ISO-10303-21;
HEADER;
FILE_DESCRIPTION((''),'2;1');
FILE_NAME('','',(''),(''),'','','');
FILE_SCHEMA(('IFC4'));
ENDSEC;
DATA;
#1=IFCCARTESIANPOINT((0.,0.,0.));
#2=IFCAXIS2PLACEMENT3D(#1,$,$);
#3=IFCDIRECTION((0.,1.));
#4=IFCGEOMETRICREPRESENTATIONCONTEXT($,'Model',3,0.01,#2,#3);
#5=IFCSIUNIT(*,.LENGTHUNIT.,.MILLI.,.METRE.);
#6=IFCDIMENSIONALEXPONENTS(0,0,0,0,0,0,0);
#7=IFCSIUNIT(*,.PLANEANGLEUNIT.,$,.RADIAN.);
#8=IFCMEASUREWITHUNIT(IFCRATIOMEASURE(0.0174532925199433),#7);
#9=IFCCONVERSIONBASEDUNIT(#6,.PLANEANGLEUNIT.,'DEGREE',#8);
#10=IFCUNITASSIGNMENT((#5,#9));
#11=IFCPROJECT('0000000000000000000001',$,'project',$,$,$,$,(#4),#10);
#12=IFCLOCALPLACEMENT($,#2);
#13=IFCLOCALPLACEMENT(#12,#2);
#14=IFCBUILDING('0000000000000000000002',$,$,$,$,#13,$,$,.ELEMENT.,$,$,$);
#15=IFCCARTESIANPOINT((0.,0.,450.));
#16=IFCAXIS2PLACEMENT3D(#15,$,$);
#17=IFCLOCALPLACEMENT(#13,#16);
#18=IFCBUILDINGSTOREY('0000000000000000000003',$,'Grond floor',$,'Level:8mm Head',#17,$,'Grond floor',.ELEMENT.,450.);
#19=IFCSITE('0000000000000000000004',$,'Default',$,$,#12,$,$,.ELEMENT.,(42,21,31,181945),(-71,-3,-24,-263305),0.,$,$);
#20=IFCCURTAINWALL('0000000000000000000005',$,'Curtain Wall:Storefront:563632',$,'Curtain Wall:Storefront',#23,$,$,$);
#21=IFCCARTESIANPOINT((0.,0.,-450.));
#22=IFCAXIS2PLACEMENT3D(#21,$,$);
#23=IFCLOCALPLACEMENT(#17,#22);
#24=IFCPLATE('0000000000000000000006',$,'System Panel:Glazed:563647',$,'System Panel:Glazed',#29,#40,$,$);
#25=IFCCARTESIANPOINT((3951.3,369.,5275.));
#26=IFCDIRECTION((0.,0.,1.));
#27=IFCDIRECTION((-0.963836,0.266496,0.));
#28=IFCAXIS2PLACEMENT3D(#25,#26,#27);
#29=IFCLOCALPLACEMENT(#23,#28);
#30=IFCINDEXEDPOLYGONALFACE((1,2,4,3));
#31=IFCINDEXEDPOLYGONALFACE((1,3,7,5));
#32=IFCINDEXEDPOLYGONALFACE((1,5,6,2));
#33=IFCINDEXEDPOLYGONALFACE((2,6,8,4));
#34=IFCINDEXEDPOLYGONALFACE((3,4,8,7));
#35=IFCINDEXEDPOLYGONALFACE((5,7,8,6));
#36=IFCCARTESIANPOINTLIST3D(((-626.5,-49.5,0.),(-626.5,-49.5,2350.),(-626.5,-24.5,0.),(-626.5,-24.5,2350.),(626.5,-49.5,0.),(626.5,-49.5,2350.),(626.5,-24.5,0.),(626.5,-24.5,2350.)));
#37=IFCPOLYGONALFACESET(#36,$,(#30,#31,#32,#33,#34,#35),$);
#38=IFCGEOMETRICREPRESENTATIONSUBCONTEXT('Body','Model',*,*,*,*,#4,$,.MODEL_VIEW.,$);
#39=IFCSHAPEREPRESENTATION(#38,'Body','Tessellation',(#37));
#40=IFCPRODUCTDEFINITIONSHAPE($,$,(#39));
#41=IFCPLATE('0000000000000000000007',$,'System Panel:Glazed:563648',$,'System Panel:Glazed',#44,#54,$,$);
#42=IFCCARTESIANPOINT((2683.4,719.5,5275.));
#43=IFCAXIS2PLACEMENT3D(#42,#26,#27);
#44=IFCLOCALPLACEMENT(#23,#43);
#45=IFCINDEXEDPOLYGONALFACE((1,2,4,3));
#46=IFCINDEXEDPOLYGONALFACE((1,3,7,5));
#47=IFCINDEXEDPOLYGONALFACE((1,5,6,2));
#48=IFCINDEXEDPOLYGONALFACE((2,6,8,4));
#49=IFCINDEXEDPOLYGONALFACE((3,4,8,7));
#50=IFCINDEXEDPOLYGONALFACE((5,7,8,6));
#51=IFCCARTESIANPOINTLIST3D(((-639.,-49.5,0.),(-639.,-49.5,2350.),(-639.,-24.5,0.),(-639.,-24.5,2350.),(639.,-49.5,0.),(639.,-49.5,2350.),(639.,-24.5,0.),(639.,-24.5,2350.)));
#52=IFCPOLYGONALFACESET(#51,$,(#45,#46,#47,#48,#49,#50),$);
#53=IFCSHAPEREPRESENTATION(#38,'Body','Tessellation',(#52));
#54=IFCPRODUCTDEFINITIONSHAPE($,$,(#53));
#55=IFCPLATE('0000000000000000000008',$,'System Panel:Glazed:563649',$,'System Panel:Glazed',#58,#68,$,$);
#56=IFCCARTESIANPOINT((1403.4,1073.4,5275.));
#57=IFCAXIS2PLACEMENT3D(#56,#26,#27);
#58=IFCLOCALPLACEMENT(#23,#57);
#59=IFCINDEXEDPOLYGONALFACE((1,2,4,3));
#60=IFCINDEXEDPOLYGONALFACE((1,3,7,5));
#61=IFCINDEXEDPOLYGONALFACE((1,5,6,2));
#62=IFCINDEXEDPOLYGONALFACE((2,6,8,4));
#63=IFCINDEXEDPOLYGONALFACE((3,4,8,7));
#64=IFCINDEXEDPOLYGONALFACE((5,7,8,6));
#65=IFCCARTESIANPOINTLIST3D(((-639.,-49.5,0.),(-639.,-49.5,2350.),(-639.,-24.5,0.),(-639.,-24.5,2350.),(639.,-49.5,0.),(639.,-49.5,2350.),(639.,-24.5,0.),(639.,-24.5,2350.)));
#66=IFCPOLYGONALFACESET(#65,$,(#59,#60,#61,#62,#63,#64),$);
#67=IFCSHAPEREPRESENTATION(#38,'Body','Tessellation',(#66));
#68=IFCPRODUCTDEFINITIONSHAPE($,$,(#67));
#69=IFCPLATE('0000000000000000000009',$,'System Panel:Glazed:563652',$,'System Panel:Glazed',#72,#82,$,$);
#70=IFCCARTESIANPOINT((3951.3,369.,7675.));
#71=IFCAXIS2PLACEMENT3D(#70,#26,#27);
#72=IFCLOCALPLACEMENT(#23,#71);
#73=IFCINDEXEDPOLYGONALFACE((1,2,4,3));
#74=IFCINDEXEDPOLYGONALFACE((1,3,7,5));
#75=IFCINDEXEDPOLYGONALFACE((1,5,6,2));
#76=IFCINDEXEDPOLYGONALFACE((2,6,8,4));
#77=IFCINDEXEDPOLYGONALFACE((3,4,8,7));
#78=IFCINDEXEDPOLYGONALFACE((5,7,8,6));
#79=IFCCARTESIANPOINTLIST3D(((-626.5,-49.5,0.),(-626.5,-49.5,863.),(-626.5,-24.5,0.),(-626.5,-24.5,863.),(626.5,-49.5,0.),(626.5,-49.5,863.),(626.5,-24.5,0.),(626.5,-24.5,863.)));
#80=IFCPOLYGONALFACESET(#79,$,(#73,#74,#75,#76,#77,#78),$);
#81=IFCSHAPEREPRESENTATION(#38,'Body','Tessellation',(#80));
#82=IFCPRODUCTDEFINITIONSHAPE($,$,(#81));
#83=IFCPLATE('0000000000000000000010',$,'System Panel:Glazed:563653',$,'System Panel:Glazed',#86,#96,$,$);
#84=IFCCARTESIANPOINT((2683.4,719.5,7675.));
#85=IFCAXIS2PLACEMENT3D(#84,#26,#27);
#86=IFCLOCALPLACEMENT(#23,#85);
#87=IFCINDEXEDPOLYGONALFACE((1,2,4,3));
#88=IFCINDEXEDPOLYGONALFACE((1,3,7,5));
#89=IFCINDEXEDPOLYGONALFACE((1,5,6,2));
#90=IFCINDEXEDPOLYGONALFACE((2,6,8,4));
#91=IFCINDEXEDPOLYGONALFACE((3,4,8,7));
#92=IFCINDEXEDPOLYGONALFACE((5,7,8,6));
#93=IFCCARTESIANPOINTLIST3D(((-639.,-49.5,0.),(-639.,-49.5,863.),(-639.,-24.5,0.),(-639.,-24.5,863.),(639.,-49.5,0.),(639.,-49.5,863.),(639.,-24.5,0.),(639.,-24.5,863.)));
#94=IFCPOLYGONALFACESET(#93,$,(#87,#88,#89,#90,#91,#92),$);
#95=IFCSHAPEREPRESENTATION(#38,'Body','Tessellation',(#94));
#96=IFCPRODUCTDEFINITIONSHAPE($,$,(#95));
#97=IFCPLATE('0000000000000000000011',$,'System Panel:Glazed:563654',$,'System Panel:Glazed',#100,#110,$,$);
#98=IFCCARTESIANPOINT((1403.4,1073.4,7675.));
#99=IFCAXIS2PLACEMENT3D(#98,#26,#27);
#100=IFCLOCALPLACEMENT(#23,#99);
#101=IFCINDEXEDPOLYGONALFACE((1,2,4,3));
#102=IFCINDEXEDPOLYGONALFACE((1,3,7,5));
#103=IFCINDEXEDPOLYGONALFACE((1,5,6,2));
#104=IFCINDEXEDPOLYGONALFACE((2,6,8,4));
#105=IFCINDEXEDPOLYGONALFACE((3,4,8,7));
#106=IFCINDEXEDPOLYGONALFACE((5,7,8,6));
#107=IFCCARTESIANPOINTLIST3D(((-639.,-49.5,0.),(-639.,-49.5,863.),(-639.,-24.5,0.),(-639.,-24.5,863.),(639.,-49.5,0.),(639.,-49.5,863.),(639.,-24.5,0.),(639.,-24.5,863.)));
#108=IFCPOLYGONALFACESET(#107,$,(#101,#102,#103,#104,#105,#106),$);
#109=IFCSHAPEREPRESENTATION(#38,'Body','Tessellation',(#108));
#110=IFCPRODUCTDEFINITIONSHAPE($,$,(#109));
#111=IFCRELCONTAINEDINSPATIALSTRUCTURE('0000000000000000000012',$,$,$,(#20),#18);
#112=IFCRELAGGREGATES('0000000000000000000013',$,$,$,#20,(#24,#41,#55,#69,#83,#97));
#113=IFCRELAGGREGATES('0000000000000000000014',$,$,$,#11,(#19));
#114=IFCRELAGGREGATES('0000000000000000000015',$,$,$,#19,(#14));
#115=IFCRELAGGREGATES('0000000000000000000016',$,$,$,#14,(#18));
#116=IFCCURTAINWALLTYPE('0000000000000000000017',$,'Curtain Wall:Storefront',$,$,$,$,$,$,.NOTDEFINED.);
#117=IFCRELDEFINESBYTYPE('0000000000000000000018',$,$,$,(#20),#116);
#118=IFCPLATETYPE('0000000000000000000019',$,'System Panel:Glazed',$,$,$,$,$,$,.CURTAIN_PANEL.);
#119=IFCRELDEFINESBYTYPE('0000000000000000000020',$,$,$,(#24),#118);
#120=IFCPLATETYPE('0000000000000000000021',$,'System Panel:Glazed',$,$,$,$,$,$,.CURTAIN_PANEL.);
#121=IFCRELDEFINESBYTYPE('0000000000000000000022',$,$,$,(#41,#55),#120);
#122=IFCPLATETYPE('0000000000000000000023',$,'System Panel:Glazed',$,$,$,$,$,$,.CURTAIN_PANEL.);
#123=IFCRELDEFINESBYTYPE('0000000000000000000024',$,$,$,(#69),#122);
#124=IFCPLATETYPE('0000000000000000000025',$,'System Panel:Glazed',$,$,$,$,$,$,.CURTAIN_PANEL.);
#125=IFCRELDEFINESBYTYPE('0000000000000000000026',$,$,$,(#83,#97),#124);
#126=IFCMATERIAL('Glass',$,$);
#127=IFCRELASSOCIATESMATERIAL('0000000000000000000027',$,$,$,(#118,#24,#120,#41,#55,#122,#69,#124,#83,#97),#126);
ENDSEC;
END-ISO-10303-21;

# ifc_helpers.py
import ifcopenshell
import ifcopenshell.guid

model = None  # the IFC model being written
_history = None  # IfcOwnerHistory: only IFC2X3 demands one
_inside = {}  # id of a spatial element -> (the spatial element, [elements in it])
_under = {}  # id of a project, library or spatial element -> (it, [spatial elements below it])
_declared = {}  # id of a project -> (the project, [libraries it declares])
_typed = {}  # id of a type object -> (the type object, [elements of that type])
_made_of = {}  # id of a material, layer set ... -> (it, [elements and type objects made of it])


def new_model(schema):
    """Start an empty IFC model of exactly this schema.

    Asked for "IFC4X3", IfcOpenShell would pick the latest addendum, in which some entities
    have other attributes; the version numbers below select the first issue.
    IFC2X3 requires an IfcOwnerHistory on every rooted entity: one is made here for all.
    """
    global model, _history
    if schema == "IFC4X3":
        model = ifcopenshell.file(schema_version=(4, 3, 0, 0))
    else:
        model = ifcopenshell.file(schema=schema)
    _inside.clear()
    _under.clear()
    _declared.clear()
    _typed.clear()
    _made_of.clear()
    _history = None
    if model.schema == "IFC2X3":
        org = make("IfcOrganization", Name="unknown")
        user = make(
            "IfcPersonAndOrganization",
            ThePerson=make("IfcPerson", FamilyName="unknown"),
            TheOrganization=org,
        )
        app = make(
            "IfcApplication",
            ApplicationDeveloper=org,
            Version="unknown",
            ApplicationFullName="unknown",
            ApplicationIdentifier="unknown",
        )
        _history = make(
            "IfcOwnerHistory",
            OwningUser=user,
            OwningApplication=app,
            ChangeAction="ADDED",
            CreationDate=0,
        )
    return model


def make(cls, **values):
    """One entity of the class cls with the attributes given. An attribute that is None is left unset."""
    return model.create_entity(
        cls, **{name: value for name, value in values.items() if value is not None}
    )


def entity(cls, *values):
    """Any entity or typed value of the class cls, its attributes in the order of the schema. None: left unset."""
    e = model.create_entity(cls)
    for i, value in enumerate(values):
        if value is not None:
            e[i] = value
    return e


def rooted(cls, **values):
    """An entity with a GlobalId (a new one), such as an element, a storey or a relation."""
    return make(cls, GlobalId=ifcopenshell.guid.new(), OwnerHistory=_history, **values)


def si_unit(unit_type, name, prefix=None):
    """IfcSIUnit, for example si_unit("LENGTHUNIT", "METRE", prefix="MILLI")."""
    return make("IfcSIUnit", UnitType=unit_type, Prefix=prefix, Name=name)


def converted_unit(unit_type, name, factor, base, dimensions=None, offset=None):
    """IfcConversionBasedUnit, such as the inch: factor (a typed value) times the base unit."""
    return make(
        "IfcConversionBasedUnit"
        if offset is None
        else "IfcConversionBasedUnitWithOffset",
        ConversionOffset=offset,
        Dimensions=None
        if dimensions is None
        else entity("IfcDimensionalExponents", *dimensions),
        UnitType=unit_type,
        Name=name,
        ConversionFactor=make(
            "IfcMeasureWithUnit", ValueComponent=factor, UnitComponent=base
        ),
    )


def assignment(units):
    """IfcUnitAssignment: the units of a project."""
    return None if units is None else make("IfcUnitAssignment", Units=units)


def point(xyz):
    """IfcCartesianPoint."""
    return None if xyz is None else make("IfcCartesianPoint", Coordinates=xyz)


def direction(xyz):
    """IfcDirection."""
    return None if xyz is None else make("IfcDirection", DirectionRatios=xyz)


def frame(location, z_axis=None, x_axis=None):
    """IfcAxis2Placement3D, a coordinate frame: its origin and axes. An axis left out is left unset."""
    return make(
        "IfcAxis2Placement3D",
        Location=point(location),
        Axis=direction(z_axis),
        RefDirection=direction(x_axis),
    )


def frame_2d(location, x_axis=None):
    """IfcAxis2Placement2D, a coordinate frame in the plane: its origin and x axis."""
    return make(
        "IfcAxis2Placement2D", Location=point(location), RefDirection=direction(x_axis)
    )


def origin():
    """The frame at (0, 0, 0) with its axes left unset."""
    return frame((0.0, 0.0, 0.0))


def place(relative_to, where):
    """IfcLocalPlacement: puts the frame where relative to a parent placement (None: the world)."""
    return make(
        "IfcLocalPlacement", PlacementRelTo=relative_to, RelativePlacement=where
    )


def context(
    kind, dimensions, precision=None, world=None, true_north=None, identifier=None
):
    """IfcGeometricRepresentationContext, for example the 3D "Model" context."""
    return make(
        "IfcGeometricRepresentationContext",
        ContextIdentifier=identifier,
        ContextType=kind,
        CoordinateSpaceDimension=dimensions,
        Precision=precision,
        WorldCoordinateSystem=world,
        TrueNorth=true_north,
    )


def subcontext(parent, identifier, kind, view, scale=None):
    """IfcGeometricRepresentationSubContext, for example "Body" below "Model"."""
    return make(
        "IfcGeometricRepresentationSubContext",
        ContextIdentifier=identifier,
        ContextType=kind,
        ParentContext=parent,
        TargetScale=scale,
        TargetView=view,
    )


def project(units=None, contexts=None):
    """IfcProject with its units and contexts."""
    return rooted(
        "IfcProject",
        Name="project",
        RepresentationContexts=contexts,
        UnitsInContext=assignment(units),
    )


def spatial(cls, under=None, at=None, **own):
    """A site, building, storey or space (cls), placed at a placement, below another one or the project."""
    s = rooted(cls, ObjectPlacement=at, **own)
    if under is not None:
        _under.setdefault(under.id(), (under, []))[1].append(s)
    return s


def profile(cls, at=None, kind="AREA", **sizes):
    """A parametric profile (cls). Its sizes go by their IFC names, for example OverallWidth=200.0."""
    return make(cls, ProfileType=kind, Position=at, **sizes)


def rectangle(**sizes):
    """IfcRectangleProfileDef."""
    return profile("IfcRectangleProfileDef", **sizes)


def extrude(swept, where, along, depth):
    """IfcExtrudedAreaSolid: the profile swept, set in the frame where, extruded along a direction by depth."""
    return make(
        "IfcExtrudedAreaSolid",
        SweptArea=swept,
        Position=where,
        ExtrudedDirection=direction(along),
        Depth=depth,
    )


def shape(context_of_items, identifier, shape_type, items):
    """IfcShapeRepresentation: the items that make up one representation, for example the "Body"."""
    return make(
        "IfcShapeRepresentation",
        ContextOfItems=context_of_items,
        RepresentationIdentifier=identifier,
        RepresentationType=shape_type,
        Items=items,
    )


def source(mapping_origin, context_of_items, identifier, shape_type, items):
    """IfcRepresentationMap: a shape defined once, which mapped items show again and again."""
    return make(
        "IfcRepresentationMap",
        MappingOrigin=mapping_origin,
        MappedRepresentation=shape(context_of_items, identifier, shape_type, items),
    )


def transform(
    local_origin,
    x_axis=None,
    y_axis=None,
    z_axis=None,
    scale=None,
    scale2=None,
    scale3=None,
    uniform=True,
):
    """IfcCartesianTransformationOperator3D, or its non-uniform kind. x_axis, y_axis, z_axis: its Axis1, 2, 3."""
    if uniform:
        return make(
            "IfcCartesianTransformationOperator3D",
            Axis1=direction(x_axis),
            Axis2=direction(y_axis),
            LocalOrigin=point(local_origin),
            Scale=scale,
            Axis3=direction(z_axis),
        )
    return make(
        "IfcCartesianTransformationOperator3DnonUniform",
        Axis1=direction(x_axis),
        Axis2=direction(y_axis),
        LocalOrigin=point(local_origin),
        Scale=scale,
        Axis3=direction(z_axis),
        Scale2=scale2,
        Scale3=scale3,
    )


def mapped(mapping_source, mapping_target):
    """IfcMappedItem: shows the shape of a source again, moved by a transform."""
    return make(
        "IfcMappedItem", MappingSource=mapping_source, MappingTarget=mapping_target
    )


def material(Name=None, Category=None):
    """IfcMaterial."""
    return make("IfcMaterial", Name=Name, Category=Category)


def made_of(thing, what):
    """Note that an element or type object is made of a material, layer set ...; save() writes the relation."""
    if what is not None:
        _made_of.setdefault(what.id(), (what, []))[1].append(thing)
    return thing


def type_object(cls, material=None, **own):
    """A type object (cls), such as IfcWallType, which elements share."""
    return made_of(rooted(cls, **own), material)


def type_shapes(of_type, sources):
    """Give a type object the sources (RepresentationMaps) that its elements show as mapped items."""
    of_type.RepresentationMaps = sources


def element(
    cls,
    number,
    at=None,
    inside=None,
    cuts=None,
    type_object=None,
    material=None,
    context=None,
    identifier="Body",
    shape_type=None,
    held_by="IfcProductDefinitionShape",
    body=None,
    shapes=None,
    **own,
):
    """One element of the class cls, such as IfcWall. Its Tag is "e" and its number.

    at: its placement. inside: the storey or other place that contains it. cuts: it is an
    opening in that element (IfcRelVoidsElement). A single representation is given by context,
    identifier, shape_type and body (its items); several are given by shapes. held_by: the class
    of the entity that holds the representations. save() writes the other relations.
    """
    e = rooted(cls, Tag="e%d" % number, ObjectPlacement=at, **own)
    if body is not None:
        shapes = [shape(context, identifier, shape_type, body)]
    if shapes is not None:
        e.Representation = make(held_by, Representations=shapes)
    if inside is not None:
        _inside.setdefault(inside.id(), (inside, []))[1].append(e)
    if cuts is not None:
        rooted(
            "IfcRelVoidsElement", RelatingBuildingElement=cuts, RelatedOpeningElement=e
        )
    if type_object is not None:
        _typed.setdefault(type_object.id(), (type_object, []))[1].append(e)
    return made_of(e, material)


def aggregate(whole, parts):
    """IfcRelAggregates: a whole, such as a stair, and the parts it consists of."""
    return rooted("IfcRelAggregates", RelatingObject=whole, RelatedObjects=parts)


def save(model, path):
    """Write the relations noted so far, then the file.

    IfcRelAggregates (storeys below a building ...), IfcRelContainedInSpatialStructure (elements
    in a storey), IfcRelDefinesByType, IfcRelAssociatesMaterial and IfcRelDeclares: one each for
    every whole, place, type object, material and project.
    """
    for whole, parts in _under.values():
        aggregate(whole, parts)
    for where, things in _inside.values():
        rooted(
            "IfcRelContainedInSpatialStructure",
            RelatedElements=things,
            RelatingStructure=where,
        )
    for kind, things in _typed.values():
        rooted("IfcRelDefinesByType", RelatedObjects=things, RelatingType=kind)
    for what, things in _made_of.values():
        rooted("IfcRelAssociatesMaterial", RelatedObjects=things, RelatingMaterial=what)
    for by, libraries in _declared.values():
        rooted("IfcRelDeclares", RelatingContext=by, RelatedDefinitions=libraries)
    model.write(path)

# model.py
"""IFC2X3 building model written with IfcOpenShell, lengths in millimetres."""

from ifc_helpers import new_model, entity, si_unit, converted_unit, direction, frame, frame_2d, origin, place, context, subcontext, project, spatial, rectangle, extrude, source, transform, mapped, material, type_object, type_shapes, element, aggregate, save


model = new_model("IFC2X3")

# Units and contexts
model_context = context("Model", 3, precision=0.01, world=origin(), true_north=direction((0.0, 1.0)))
body_context = subcontext(model_context, "Body", "Model", "MODEL_VIEW")
ifc_project = project(units=[si_unit("LENGTHUNIT", "METRE", prefix="MILLI"), converted_unit("PLANEANGLEUNIT", "DEGREE", entity("IfcRatioMeasure", 0.0174532925199433), si_unit("PLANEANGLEUNIT", "RADIAN"), dimensions=[0, 0, 0, 0, 0, 0, 0])], contexts=[model_context])

# Site, building, storey
site_placement = place(None, origin())
site = spatial("IfcSite", under=ifc_project, at=site_placement, Name="Default", CompositionType="ELEMENT", RefLatitude=(42, 21, 31, 181945), RefLongitude=(-71, -3, -24, -263305), RefElevation=0.0)
building_placement = place(site_placement, origin())
building = spatial("IfcBuilding", under=site, at=building_placement, CompositionType="ELEMENT")
storey_placement = place(building_placement, frame((0.0, 0.0, 450.0)))
storey = spatial("IfcBuildingStorey", under=building, at=storey_placement, Name="Grond floor", ObjectType="Level:8mm Head", LongName="Grond floor", CompositionType="ELEMENT", Elevation=450.0)

# Curtain wall, plates
curtain_wall_type = type_object("IfcCurtainWallType", Name="Curtain Wall:Storefront", PredefinedType="NOTDEFINED")
curtain_wall_placement = place(storey_placement, frame((0.0, 0.0, -450.0)))
curtain_wall = element("IfcCurtainWall", 1, at=curtain_wall_placement, inside=storey, type_object=curtain_wall_type, Name="Curtain Wall:Storefront:563632", ObjectType="Curtain Wall:Storefront")
ifc_material_1 = material(Name="Glass")
plate_type_1 = type_object("IfcPlateType", Name="System Panel:Glazed", PredefinedType="CURTAIN_PANEL", material=ifc_material_1)
shared_shape_1 = source(origin(), body_context, "Body", "SweptSolid", [
    extrude(rectangle(XDim=25.0, YDim=1253.0, at=frame_2d((0.0, 0.0), x_axis=(1.0, 0.0))), frame((0.0, -37.0, 0.0), z_axis=(0.0, 0.0, 1.0), x_axis=(0.0, 1.0, 0.0)), (0.0, 0.0, 1.0), 2350.0),
])
type_shapes(plate_type_1, [shared_shape_1])
plate_1_placement = place(curtain_wall_placement, frame((3951.3, 369.0, 5275.0), z_axis=(0.0, 0.0, 1.0), x_axis=(-0.963836, 0.266496, 0.0)))
plate_1 = element("IfcPlate", 2, at=plate_1_placement, type_object=plate_type_1, material=ifc_material_1, Name="System Panel:Glazed:563647", ObjectType="System Panel:Glazed", context=body_context, shape_type="MappedRepresentation", body=[
    mapped(shared_shape_1, transform((0.0, 0.0, 0.0), scale=1.0)),
])
plate_type_2 = type_object("IfcPlateType", Name="System Panel:Glazed", PredefinedType="CURTAIN_PANEL", material=ifc_material_1)
shared_shape_2 = source(origin(), body_context, "Body", "SweptSolid", [
    extrude(rectangle(XDim=25.0, YDim=1278.0, at=frame_2d((0.0, 0.0), x_axis=(1.0, 0.0))), frame((0.0, -37.0, 0.0), z_axis=(0.0, 0.0, 1.0), x_axis=(0.0, 1.0, 0.0)), (0.0, 0.0, 1.0), 2350.0),
])
type_shapes(plate_type_2, [shared_shape_2])
plate_2_placement = place(curtain_wall_placement, frame((2683.4, 719.5, 5275.0), z_axis=(0.0, 0.0, 1.0), x_axis=(-0.963836, 0.266496, 0.0)))
plate_2 = element("IfcPlate", 3, at=plate_2_placement, type_object=plate_type_2, material=ifc_material_1, Name="System Panel:Glazed:563648", ObjectType="System Panel:Glazed", context=body_context, shape_type="MappedRepresentation", body=[
    mapped(shared_shape_2, transform((0.0, 0.0, 0.0), scale=1.0)),
])
plate_3_placement = place(curtain_wall_placement, frame((1403.4, 1073.4, 5275.0), z_axis=(0.0, 0.0, 1.0), x_axis=(-0.963836, 0.266496, 0.0)))
plate_3 = element("IfcPlate", 4, at=plate_3_placement, type_object=plate_type_2, material=ifc_material_1, Name="System Panel:Glazed:563649", ObjectType="System Panel:Glazed", context=body_context, shape_type="MappedRepresentation", body=[
    mapped(shared_shape_2, transform((0.0, 0.0, 0.0), scale=1.0)),
])
plate_type_3 = type_object("IfcPlateType", Name="System Panel:Glazed", PredefinedType="CURTAIN_PANEL", material=ifc_material_1)
shared_shape_3 = source(origin(), body_context, "Body", "SweptSolid", [
    extrude(rectangle(XDim=25.0, YDim=1253.0, at=frame_2d((0.0, 0.0), x_axis=(1.0, 0.0))), frame((0.0, -37.0, 0.0), z_axis=(0.0, 0.0, 1.0), x_axis=(0.0, 1.0, 0.0)), (0.0, 0.0, 1.0), 863.0),
])
type_shapes(plate_type_3, [shared_shape_3])
plate_4_placement = place(curtain_wall_placement, frame((3951.3, 369.0, 7675.0), z_axis=(0.0, 0.0, 1.0), x_axis=(-0.963836, 0.266496, 0.0)))
plate_4 = element("IfcPlate", 5, at=plate_4_placement, type_object=plate_type_3, material=ifc_material_1, Name="System Panel:Glazed:563652", ObjectType="System Panel:Glazed", context=body_context, shape_type="MappedRepresentation", body=[
    mapped(shared_shape_3, transform((0.0, 0.0, 0.0), scale=1.0)),
])
plate_type_4 = type_object("IfcPlateType", Name="System Panel:Glazed", PredefinedType="CURTAIN_PANEL", material=ifc_material_1)
shared_shape_4 = source(origin(), body_context, "Body", "SweptSolid", [
    extrude(rectangle(XDim=25.0, YDim=1278.0, at=frame_2d((0.0, 0.0), x_axis=(1.0, 0.0))), frame((0.0, -37.0, 0.0), z_axis=(0.0, 0.0, 1.0), x_axis=(0.0, 1.0, 0.0)), (0.0, 0.0, 1.0), 863.0),
])
type_shapes(plate_type_4, [shared_shape_4])
plate_5_placement = place(curtain_wall_placement, frame((2683.4, 719.5, 7675.0), z_axis=(0.0, 0.0, 1.0), x_axis=(-0.963836, 0.266496, 0.0)))
plate_5 = element("IfcPlate", 6, at=plate_5_placement, type_object=plate_type_4, material=ifc_material_1, Name="System Panel:Glazed:563653", ObjectType="System Panel:Glazed", context=body_context, shape_type="MappedRepresentation", body=[
    mapped(shared_shape_4, transform((0.0, 0.0, 0.0), scale=1.0)),
])
plate_6_placement = place(curtain_wall_placement, frame((1403.4, 1073.4, 7675.0), z_axis=(0.0, 0.0, 1.0), x_axis=(-0.963836, 0.266496, 0.0)))
plate_6 = element("IfcPlate", 7, at=plate_6_placement, type_object=plate_type_4, material=ifc_material_1, Name="System Panel:Glazed:563654", ObjectType="System Panel:Glazed", context=body_context, shape_type="MappedRepresentation", body=[
    mapped(shared_shape_4, transform((0.0, 0.0, 0.0), scale=1.0)),
])
aggregate(curtain_wall, [plate_1, plate_2, plate_3, plate_4, plate_5, plate_6])

save(model, "model.ifc")
